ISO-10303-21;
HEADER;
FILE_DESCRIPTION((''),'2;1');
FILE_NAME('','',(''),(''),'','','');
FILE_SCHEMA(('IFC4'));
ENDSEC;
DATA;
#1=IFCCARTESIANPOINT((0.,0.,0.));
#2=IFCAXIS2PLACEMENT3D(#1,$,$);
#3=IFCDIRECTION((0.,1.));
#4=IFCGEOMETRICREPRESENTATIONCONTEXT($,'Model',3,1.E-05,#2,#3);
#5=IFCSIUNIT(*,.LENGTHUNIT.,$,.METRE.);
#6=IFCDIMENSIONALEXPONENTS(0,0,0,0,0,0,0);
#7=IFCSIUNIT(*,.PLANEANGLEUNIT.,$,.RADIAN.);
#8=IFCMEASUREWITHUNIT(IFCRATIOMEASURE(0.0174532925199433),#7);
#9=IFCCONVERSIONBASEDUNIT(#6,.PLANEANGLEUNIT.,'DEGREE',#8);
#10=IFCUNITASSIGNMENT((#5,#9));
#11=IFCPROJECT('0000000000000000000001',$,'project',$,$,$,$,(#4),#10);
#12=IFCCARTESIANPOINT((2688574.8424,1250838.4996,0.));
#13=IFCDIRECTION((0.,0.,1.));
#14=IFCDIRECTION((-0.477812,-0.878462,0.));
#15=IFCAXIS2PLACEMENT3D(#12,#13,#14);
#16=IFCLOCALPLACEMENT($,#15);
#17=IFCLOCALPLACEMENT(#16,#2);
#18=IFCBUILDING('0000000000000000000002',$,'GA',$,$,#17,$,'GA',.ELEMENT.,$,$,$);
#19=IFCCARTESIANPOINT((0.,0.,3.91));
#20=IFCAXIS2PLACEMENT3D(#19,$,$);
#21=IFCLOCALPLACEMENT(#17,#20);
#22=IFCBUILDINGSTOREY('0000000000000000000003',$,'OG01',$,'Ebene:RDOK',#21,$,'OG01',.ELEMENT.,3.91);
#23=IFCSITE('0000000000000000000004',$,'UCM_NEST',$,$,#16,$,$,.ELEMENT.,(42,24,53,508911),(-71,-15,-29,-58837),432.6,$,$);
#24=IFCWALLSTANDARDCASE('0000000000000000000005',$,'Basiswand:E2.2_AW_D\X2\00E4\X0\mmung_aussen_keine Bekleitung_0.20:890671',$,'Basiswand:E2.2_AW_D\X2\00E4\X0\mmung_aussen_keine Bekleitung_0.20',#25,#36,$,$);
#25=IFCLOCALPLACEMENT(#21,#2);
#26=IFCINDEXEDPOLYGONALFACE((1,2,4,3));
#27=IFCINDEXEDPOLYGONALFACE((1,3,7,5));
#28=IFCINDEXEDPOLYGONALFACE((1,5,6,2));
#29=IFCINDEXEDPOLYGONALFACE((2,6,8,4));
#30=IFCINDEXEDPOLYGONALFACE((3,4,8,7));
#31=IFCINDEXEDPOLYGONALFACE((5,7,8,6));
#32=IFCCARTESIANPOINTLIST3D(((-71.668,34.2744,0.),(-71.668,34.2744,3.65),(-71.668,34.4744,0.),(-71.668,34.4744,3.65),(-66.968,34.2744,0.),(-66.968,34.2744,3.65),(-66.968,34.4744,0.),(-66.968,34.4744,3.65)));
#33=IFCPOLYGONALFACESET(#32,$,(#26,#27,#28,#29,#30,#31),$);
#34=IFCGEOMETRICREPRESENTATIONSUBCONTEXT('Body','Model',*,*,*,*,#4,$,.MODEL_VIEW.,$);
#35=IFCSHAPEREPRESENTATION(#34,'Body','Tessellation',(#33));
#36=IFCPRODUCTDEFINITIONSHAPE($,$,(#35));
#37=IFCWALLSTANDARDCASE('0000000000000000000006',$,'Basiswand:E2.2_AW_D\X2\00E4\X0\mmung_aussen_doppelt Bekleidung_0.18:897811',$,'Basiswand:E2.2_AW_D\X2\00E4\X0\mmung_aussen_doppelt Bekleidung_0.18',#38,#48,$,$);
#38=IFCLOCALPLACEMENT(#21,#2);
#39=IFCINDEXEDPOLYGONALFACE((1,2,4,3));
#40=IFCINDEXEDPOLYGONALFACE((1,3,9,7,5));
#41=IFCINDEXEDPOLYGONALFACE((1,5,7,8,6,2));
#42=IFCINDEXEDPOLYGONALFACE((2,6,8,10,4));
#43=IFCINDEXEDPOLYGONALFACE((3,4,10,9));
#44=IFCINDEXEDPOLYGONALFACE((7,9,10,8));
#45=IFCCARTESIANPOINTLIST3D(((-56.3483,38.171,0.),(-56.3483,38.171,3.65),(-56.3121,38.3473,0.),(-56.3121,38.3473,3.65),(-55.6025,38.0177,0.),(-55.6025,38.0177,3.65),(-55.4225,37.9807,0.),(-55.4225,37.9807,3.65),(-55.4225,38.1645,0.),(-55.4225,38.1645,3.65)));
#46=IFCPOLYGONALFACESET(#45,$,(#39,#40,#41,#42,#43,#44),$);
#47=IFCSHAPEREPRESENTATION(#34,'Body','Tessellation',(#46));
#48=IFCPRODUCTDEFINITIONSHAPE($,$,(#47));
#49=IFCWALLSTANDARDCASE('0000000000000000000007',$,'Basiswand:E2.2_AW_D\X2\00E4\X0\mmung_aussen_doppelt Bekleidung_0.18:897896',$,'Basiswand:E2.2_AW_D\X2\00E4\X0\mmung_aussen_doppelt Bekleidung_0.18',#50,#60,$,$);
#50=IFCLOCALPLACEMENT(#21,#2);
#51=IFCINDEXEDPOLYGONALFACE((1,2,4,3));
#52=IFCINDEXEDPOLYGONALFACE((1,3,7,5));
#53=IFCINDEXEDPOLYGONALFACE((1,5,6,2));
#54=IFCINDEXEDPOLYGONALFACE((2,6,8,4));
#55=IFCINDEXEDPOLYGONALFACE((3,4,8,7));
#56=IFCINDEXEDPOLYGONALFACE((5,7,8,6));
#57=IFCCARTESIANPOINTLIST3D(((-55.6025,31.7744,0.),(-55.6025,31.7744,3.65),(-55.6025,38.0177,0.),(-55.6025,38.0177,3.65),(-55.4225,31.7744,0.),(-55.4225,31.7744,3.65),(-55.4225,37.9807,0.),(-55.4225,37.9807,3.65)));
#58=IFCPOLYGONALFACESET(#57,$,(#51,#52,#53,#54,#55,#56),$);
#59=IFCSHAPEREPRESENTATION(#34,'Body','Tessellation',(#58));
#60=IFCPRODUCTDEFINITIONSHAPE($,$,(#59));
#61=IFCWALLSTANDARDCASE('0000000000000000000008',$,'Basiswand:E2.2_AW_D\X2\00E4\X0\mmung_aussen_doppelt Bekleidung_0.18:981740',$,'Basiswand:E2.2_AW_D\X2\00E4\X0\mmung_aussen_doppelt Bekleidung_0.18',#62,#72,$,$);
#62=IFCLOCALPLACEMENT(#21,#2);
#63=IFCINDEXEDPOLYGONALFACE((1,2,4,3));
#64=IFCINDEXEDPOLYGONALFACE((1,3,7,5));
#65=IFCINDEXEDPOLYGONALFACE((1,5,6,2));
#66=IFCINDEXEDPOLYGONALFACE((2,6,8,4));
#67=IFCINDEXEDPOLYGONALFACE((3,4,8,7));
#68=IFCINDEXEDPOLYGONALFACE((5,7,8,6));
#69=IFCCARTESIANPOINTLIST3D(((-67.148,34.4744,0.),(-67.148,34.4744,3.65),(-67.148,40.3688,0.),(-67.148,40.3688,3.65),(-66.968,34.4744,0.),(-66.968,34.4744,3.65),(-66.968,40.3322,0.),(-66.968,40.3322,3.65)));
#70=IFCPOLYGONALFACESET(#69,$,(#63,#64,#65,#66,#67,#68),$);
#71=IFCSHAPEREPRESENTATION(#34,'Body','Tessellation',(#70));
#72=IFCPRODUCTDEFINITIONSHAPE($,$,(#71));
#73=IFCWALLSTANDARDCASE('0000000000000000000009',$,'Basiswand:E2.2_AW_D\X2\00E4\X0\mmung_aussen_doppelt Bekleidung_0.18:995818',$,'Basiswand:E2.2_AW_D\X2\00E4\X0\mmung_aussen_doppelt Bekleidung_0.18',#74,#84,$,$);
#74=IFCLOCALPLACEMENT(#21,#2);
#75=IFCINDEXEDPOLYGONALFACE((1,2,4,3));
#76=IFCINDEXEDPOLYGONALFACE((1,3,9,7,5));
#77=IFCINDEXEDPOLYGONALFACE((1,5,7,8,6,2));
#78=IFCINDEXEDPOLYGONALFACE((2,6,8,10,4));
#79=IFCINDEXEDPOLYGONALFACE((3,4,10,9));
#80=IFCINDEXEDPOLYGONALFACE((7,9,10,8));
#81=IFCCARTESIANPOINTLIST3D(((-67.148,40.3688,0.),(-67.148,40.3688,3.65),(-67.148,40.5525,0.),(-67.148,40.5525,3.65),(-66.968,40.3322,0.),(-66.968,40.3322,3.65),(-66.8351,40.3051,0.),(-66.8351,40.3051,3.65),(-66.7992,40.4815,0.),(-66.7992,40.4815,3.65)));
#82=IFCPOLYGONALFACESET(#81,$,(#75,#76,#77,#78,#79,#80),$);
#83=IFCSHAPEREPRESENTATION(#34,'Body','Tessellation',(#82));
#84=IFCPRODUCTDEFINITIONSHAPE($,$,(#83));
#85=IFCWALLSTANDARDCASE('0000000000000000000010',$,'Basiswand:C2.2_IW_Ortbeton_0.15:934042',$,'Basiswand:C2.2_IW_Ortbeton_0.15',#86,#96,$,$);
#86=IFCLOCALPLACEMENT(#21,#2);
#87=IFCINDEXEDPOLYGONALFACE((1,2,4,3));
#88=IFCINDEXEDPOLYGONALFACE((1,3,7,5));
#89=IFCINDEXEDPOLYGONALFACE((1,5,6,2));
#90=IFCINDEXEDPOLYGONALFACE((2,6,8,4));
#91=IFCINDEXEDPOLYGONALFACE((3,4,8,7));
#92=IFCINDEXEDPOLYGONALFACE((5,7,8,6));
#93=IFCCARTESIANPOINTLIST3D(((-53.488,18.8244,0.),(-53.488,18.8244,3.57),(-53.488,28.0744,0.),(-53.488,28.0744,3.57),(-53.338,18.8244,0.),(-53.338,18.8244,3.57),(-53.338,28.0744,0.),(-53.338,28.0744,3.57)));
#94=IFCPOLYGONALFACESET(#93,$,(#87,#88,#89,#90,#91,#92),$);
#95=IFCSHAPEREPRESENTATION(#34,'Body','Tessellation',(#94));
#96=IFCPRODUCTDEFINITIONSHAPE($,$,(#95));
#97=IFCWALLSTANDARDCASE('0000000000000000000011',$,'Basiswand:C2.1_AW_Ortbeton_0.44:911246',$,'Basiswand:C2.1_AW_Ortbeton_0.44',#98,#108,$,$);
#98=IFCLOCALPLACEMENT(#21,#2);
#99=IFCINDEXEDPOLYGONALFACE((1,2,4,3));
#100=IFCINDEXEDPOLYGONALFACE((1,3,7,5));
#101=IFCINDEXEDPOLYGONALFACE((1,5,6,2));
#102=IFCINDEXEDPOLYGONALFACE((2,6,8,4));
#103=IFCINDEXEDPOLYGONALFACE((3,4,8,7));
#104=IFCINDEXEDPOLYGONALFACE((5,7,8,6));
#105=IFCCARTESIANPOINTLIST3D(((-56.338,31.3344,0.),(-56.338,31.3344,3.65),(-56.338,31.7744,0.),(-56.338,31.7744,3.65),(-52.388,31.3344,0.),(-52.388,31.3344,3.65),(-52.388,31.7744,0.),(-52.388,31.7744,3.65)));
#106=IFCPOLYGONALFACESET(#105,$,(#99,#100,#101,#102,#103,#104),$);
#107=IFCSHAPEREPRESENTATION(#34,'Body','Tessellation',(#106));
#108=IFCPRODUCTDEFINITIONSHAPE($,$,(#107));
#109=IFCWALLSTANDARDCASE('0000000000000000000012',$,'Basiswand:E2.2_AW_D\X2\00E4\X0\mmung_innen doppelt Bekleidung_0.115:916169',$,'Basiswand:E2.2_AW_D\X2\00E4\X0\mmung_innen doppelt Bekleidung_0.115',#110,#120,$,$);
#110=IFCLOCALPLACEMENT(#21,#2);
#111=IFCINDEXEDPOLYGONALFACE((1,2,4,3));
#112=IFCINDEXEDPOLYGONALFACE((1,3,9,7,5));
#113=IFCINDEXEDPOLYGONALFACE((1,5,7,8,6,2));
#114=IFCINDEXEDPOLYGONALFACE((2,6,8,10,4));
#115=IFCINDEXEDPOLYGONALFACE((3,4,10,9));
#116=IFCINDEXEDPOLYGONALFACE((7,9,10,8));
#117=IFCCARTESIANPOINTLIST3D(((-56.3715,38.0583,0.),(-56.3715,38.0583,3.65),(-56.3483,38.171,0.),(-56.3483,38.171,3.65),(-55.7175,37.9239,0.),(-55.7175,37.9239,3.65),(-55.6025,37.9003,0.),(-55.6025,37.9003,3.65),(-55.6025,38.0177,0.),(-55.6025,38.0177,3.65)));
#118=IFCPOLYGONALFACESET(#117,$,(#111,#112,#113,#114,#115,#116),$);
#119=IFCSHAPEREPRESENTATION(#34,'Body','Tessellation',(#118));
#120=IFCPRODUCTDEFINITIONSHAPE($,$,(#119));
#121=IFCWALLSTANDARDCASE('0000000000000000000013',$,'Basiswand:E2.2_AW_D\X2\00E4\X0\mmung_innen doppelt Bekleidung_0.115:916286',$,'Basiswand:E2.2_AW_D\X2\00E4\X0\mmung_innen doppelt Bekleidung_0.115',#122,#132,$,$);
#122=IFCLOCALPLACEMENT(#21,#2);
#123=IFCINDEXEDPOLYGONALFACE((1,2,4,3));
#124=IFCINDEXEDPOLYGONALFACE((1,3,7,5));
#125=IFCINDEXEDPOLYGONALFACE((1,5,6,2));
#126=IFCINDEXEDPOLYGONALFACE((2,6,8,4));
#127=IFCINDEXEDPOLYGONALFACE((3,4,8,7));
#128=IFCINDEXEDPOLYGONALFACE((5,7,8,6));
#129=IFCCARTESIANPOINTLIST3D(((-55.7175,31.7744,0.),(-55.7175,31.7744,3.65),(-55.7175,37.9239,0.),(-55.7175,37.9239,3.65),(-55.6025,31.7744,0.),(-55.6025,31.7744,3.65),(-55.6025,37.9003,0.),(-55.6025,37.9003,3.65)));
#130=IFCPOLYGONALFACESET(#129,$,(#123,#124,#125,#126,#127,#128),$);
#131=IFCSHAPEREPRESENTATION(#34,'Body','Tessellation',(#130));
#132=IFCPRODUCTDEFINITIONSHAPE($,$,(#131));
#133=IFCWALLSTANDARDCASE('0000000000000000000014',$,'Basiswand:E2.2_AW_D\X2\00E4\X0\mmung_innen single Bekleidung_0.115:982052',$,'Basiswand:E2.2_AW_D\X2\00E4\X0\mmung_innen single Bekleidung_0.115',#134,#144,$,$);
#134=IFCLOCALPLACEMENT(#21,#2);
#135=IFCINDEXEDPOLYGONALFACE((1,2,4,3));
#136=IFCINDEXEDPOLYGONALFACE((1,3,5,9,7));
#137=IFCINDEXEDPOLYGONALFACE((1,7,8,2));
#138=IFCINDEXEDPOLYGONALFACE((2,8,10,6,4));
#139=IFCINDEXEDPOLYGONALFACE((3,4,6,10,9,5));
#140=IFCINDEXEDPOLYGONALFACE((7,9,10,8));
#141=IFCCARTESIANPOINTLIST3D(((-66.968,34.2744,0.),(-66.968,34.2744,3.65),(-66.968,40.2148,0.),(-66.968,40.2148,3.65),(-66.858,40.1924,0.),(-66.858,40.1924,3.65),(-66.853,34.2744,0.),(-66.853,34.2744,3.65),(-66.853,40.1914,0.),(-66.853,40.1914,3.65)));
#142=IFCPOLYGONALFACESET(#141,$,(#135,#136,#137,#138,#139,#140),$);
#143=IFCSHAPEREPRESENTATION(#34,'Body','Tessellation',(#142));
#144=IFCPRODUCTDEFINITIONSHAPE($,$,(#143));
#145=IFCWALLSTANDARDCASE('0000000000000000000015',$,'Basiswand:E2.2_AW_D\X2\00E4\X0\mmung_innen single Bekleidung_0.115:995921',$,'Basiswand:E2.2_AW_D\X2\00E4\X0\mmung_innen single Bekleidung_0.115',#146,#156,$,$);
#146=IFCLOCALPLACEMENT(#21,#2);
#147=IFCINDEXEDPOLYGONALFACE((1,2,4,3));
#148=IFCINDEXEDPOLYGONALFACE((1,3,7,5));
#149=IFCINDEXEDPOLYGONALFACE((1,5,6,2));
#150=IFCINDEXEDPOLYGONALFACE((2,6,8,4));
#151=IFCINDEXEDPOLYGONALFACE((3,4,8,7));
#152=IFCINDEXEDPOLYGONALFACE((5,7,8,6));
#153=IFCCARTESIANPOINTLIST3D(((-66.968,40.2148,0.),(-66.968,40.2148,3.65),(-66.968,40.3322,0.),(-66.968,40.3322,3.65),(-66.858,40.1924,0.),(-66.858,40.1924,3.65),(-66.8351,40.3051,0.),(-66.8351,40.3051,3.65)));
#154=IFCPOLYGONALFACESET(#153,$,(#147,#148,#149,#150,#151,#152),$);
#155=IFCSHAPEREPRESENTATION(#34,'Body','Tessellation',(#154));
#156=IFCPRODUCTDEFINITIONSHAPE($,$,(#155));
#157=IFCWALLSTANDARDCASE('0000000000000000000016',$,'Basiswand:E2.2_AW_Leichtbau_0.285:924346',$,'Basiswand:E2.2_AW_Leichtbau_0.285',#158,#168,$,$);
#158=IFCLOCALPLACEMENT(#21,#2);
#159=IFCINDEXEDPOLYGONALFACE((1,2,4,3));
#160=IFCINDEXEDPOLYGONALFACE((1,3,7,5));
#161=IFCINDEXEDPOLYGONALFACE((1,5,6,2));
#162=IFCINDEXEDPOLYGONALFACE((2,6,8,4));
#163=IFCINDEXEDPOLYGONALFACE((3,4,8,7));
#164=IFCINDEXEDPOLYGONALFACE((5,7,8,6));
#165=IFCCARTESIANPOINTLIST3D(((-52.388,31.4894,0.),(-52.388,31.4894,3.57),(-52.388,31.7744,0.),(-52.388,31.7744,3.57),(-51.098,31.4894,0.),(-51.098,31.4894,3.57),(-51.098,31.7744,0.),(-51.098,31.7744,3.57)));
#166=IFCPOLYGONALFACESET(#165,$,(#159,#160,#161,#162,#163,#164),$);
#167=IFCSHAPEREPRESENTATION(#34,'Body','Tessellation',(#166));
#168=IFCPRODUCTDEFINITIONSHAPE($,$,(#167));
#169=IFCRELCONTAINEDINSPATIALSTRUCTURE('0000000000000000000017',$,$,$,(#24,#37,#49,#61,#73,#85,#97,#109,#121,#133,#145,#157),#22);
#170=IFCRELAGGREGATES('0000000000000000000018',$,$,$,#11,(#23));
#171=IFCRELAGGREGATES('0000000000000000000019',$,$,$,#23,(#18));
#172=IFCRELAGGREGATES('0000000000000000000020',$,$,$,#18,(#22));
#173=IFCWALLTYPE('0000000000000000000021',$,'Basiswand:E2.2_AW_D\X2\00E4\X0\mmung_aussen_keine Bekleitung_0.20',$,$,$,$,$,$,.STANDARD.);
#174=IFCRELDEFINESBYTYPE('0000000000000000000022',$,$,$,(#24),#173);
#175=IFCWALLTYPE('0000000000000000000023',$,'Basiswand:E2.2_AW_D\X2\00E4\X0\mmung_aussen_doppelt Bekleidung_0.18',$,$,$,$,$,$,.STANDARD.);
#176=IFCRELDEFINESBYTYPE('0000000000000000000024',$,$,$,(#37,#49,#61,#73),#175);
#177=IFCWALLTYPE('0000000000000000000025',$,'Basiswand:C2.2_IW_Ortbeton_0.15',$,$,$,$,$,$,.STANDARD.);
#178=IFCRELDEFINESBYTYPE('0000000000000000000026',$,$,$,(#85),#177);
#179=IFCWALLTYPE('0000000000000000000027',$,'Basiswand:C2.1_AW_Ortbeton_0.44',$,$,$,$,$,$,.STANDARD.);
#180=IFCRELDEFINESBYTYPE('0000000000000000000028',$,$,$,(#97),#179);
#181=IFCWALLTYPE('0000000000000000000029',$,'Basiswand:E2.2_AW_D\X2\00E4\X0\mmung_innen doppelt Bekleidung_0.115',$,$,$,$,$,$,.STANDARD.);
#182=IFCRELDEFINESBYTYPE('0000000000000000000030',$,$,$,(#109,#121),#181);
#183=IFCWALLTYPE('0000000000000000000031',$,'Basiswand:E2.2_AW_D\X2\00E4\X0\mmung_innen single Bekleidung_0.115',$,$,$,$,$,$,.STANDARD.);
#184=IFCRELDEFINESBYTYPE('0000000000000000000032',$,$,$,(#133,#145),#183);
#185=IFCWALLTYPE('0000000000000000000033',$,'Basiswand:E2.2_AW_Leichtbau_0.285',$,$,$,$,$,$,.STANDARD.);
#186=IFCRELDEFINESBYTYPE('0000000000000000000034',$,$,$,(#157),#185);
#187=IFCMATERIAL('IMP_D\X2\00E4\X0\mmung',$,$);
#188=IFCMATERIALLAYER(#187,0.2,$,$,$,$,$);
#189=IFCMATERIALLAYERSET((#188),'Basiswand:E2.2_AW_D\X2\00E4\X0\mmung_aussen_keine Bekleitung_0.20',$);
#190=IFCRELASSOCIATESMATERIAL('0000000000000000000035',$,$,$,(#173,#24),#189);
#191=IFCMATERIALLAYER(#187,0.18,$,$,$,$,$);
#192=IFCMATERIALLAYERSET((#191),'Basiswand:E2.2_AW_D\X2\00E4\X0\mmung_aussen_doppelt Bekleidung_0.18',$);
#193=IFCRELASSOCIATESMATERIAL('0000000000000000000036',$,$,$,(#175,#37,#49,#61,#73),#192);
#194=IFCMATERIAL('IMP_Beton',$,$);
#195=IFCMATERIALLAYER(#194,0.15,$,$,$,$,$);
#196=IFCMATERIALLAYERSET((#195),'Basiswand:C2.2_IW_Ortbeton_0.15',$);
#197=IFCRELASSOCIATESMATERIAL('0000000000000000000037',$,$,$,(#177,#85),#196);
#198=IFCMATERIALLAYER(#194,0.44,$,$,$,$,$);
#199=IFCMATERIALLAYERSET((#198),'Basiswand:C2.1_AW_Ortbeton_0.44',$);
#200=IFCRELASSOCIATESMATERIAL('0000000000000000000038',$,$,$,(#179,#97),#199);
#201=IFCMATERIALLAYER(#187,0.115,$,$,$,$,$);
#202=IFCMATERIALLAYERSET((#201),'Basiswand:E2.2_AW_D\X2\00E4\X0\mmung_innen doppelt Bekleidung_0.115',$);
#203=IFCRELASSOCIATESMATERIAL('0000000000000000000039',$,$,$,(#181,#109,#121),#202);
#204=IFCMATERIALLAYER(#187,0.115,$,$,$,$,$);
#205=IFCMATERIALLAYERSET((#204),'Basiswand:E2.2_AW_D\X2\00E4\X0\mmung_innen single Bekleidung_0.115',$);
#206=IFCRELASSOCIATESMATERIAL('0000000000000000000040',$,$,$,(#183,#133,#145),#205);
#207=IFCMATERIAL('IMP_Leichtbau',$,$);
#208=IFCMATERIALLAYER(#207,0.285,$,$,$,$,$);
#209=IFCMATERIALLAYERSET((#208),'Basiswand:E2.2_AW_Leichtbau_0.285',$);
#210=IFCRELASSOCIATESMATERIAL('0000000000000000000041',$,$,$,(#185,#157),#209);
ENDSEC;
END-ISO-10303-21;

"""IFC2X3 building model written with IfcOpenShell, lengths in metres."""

from ifc_helpers import new_model, entity, si_unit, converted_unit, direction, frame, frame_2d, origin, place, context, subcontext, project, spatial, polyline, rectangle, outline, extrude, clip, bounded_halfspace, material, layer, layer_set, layer_usage, type_object, element, save


model = new_model("IFC2X3")

# Units and contexts
model_context = context("Model", 3, precision=1e-05, world=origin(), true_north=direction((0.0, 1.0)))
body_context = subcontext(model_context, "Body", "Model", "MODEL_VIEW")
ifc_project = project(units=[si_unit("LENGTHUNIT", "METRE"), converted_unit("PLANEANGLEUNIT", "DEGREE", entity("IfcRatioMeasure", 0.0174532925199433), si_unit("PLANEANGLEUNIT", "RADIAN"), dimensions=[0, 0, 0, 0, 0, 0, 0])], contexts=[model_context])

# Site, building, storey
site_placement = place(None, frame((2688574.8424, 1250838.4996, 0.0), z_axis=(0.0, 0.0, 1.0), x_axis=(-0.477812, -0.878462, 0.0)))
site = spatial("IfcSite", under=ifc_project, at=site_placement, Name="UCM_NEST", CompositionType="ELEMENT", RefLatitude=(42, 24, 53, 508911), RefLongitude=(-71, -15, -29, -58837), RefElevation=432.6)
building_placement = place(site_placement, origin())
building = spatial("IfcBuilding", under=site, at=building_placement, Name="GA", LongName="GA", CompositionType="ELEMENT")
storey_placement = place(building_placement, frame((0.0, 0.0, 3.91)))
storey = spatial("IfcBuildingStorey", under=building, at=storey_placement, Name="OG01", ObjectType="Ebene:RDOK", LongName="OG01", CompositionType="ELEMENT", Elevation=3.91)

# Walls
ifc_material_1 = material(Name="IMP_Dämmung")
ifc_layer_1 = layer(ifc_material_1, 0.2)
ifc_layer_set_1 = layer_set([ifc_layer_1], Name="Basiswand:E2.2_AW_Dämmung_aussen_keine Bekleitung_0.20")
ifc_layer_usage_1 = layer_usage(ifc_layer_set_1, "AXIS2", "NEGATIVE", 0.1)
wall_type_1 = type_object("IfcWallType", Name="Basiswand:E2.2_AW_Dämmung_aussen_keine Bekleitung_0.20", PredefinedType="STANDARD", material=ifc_layer_set_1)
wall_1_placement = place(storey_placement, frame((-66.968, 34.3744, 0.0), z_axis=(0.0, 0.0, 1.0), x_axis=(-1.0, 0.0, 0.0)))
element("IfcWallStandardCase", 1, at=wall_1_placement, inside=storey, type_object=wall_type_1, material=ifc_layer_usage_1, Name="Basiswand:E2.2_AW_Dämmung_aussen_keine Bekleitung_0.20:890671", ObjectType="Basiswand:E2.2_AW_Dämmung_aussen_keine Bekleitung_0.20", context=body_context, shape_type="SweptSolid", body=[
    extrude(rectangle(XDim=4.7, YDim=0.2, at=frame_2d((2.35, 0.0), x_axis=(-1.0, 0.0))), origin(), (0.0, 0.0, 1.0), 3.65),
])
ifc_layer_2 = layer(ifc_material_1, 0.18)
ifc_layer_set_2 = layer_set([ifc_layer_2], Name="Basiswand:E2.2_AW_Dämmung_aussen_doppelt Bekleidung_0.18")
ifc_layer_usage_2 = layer_usage(ifc_layer_set_2, "AXIS2", "NEGATIVE", 0.09)
wall_type_2 = type_object("IfcWallType", Name="Basiswand:E2.2_AW_Dämmung_aussen_doppelt Bekleidung_0.18", PredefinedType="STANDARD", material=ifc_layer_set_2)
wall_2_placement = place(storey_placement, frame((-56.3302, 38.2591, 0.0), z_axis=(0.0, 0.0, 1.0), x_axis=(0.979529, -0.201305, 0.0)))
element("IfcWallStandardCase", 2, at=wall_2_placement, inside=storey, type_object=wall_type_2, material=ifc_layer_usage_2, Name="Basiswand:E2.2_AW_Dämmung_aussen_doppelt Bekleidung_0.18:897811", ObjectType="Basiswand:E2.2_AW_Dämmung_aussen_doppelt Bekleidung_0.18", context=body_context, shape_type="SweptSolid", body=[
    extrude(outline(polyline([(0.9451, -0.09), (0.9081, 0.09), (0.0, 0.09), (0.0, -0.09), (0.7614, -0.09), (0.9451, -0.09)])), origin(), (0.0, 0.0, 1.0), 3.65),
])
ifc_layer_usage_3 = layer_usage(ifc_layer_set_2, "AXIS2", "NEGATIVE", 0.09)
wall_3_placement = place(storey_placement, frame((-55.5125, 38.0177, 0.0), z_axis=(0.0, 0.0, 1.0), x_axis=(0.0, -1.0, 0.0)))
element("IfcWallStandardCase", 3, at=wall_3_placement, inside=storey, type_object=wall_type_2, material=ifc_layer_usage_3, Name="Basiswand:E2.2_AW_Dämmung_aussen_doppelt Bekleidung_0.18:897896", ObjectType="Basiswand:E2.2_AW_Dämmung_aussen_doppelt Bekleidung_0.18", context=body_context, shape_type="SweptSolid", body=[
    extrude(outline(polyline([(6.2433, -0.09), (6.2433, 0.09), (0.037, 0.09), (0.0, -0.09), (6.2433, -0.09)])), origin(), (0.0, 0.0, 1.0), 3.65),
])
ifc_layer_usage_4 = layer_usage(ifc_layer_set_2, "AXIS2", "NEGATIVE", 0.09)
wall_4_placement = place(storey_placement, frame((-67.058, 34.4744, 0.0), z_axis=(0.0, 0.0, 1.0), x_axis=(0.0, 1.0, 0.0)))
element("IfcWallStandardCase", 4, at=wall_4_placement, inside=storey, type_object=wall_type_2, material=ifc_layer_usage_4, Name="Basiswand:E2.2_AW_Dämmung_aussen_doppelt Bekleidung_0.18:981740", ObjectType="Basiswand:E2.2_AW_Dämmung_aussen_doppelt Bekleidung_0.18", context=body_context, shape_type="SweptSolid", body=[
    extrude(outline(polyline([(5.8577, -0.09), (5.8943, 0.09), (0.0, 0.09), (0.0, -0.09), (5.8577, -0.09)])), origin(), (0.0, 0.0, 1.0), 3.65),
])
ifc_layer_usage_5 = layer_usage(ifc_layer_set_2, "AXIS2", "NEGATIVE", 0.09)
wall_5_placement = place(storey_placement, frame((-67.1659, 40.4643, 0.0), z_axis=(0.0, 0.0, 1.0), x_axis=(0.979914, -0.199421, 0.0)))
element("IfcWallStandardCase", 5, at=wall_5_placement, inside=storey, type_object=wall_type_2, material=ifc_layer_usage_5, Name="Basiswand:E2.2_AW_Dämmung_aussen_doppelt Bekleidung_0.18:995818", ObjectType="Basiswand:E2.2_AW_Dämmung_aussen_doppelt Bekleidung_0.18", context=body_context, shape_type="SweptSolid", body=[
    extrude(outline(polyline([(0.356, -0.09), (0.356, 0.09), (0.0, 0.09), (0.0366, -0.09), (0.2203, -0.09), (0.356, -0.09)])), origin(), (0.0, 0.0, 1.0), 3.65),
])
ifc_material_2 = material(Name="IMP_Beton")
ifc_layer_3 = layer(ifc_material_2, 0.15)
ifc_layer_set_3 = layer_set([ifc_layer_3], Name="Basiswand:C2.2_IW_Ortbeton_0.15")
ifc_layer_usage_6 = layer_usage(ifc_layer_set_3, "AXIS2", "NEGATIVE", 0.075)
wall_type_3 = type_object("IfcWallType", Name="Basiswand:C2.2_IW_Ortbeton_0.15", PredefinedType="STANDARD", material=ifc_layer_set_3)
wall_6_placement = place(storey_placement, frame((-53.413, 28.0744, 0.0), z_axis=(0.0, 0.0, 1.0), x_axis=(0.0, -1.0, 0.0)))
element("IfcWallStandardCase", 6, at=wall_6_placement, inside=storey, type_object=wall_type_3, material=ifc_layer_usage_6, Name="Basiswand:C2.2_IW_Ortbeton_0.15:934042", ObjectType="Basiswand:C2.2_IW_Ortbeton_0.15", context=body_context, shape_type="Clipping", body=[
    clip(extrude(rectangle(XDim=9.25, YDim=0.15, at=frame_2d((4.625, 0.0), x_axis=(-1.0, 0.0))), origin(), (0.0, 0.0, 1.0), 3.57), bounded_halfspace(frame((0.0, -0.075, 3.57), z_axis=(0.0, 0.0, -1.0), x_axis=(1.0, 0.0, 0.0)), True, frame((0.0, -0.075, 3.57), z_axis=(0.0, 0.0, -1.0), x_axis=(1.0, 0.0, 0.0)), polyline([(0.0, 0.0), (0.0, -0.15), (9.1, -0.15), (9.25, -0.15), (9.25, 0.0), (0.0, 0.0)]))),
])
ifc_layer_4 = layer(ifc_material_2, 0.44)
ifc_layer_set_4 = layer_set([ifc_layer_4], Name="Basiswand:C2.1_AW_Ortbeton_0.44")
ifc_layer_usage_7 = layer_usage(ifc_layer_set_4, "AXIS2", "NEGATIVE", 0.22)
wall_type_4 = type_object("IfcWallType", Name="Basiswand:C2.1_AW_Ortbeton_0.44", PredefinedType="STANDARD", material=ifc_layer_set_4)
wall_7_placement = place(storey_placement, frame((-56.338, 31.5544, 0.0)))
element("IfcWallStandardCase", 7, at=wall_7_placement, inside=storey, type_object=wall_type_4, material=ifc_layer_usage_7, Name="Basiswand:C2.1_AW_Ortbeton_0.44:911246", ObjectType="Basiswand:C2.1_AW_Ortbeton_0.44", context=body_context, shape_type="SweptSolid", body=[
    extrude(rectangle(XDim=3.95, YDim=0.44, at=frame_2d((1.975, 0.0), x_axis=(-1.0, 0.0))), origin(), (0.0, 0.0, 1.0), 3.65),
])

# Walls
ifc_layer_5 = layer(ifc_material_1, 0.115)
ifc_layer_set_5 = layer_set([ifc_layer_5], Name="Basiswand:E2.2_AW_Dämmung_innen doppelt Bekleidung_0.115")
ifc_layer_usage_8 = layer_usage(ifc_layer_set_5, "AXIS2", "NEGATIVE", 0.0575)
wall_type_5 = type_object("IfcWallType", Name="Basiswand:E2.2_AW_Dämmung_innen doppelt Bekleidung_0.115", PredefinedType="STANDARD", material=ifc_layer_set_5)
wall_8_placement = place(storey_placement, frame((-56.3599, 38.1146, 0.0), z_axis=(0.0, 0.0, 1.0), x_axis=(0.979529, -0.201305, 0.0)))
element("IfcWallStandardCase", 8, at=wall_8_placement, inside=storey, type_object=wall_type_5, material=ifc_layer_usage_8, Name="Basiswand:E2.2_AW_Dämmung_innen doppelt Bekleidung_0.115:916169", ObjectType="Basiswand:E2.2_AW_Dämmung_innen doppelt Bekleidung_0.115", context=body_context, shape_type="SweptSolid", body=[
    extrude(outline(polyline([(0.785, -0.0575), (0.7614, 0.0575), (0.0, 0.0575), (0.0, -0.0575), (0.6676, -0.0575), (0.785, -0.0575)])), origin(), (0.0, 0.0, 1.0), 3.65),
])
ifc_layer_usage_9 = layer_usage(ifc_layer_set_5, "AXIS2", "NEGATIVE", 0.0575)
wall_9_placement = place(storey_placement, frame((-55.66, 37.9239, 0.0), z_axis=(0.0, 0.0, 1.0), x_axis=(0.0, -1.0, 0.0)))
element("IfcWallStandardCase", 9, at=wall_9_placement, inside=storey, type_object=wall_type_5, material=ifc_layer_usage_9, Name="Basiswand:E2.2_AW_Dämmung_innen doppelt Bekleidung_0.115:916286", ObjectType="Basiswand:E2.2_AW_Dämmung_innen doppelt Bekleidung_0.115", context=body_context, shape_type="SweptSolid", body=[
    extrude(outline(polyline([(6.1495, -0.0575), (6.1495, 0.0575), (0.0236, 0.0575), (0.0, -0.0575), (6.1495, -0.0575)])), origin(), (0.0, 0.0, 1.0), 3.65),
])
ifc_layer_6 = layer(ifc_material_1, 0.115)
ifc_layer_set_6 = layer_set([ifc_layer_6], Name="Basiswand:E2.2_AW_Dämmung_innen single Bekleidung_0.115")
ifc_layer_usage_10 = layer_usage(ifc_layer_set_6, "AXIS2", "NEGATIVE", 0.0575)
wall_type_6 = type_object("IfcWallType", Name="Basiswand:E2.2_AW_Dämmung_innen single Bekleidung_0.115", PredefinedType="STANDARD", material=ifc_layer_set_6)
wall_10_placement = place(storey_placement, frame((-66.9105, 34.2744, 0.0), z_axis=(0.0, 0.0, 1.0), x_axis=(0.0, 1.0, 0.0)))
element("IfcWallStandardCase", 10, at=wall_10_placement, inside=storey, type_object=wall_type_6, material=ifc_layer_usage_10, Name="Basiswand:E2.2_AW_Dämmung_innen single Bekleidung_0.115:982052", ObjectType="Basiswand:E2.2_AW_Dämmung_innen single Bekleidung_0.115", context=body_context, shape_type="SweptSolid", body=[
    extrude(outline(polyline([(5.917, -0.0575), (5.918, -0.0525), (5.9404, 0.0575), (0.0, 0.0575), (0.0, -0.0575), (5.917, -0.0575)])), origin(), (0.0, 0.0, 1.0), 3.65),
])
ifc_layer_usage_11 = layer_usage(ifc_layer_set_6, "AXIS2", "NEGATIVE", 0.0575)
wall_11_placement = place(storey_placement, frame((-66.9795, 40.2758, 0.0), z_axis=(0.0, 0.0, 1.0), x_axis=(0.979914, -0.199421, 0.0)))
element("IfcWallStandardCase", 11, at=wall_11_placement, inside=storey, type_object=wall_type_6, material=ifc_layer_usage_11, Name="Basiswand:E2.2_AW_Dämmung_innen single Bekleidung_0.115:995921", ObjectType="Basiswand:E2.2_AW_Dämmung_innen single Bekleidung_0.115", context=body_context, shape_type="SweptSolid", body=[
    extrude(outline(polyline([(0.1357, -0.0575), (0.1357, 0.0575), (0.0, 0.0575), (0.0234, -0.0575), (0.1357, -0.0575)])), origin(), (0.0, 0.0, 1.0), 3.65),
])
ifc_material_3 = material(Name="IMP_Leichtbau")
ifc_layer_7 = layer(ifc_material_3, 0.285)
ifc_layer_set_7 = layer_set([ifc_layer_7], Name="Basiswand:E2.2_AW_Leichtbau_0.285")
ifc_layer_usage_12 = layer_usage(ifc_layer_set_7, "AXIS2", "NEGATIVE", 0.1425)
wall_type_7 = type_object("IfcWallType", Name="Basiswand:E2.2_AW_Leichtbau_0.285", PredefinedType="STANDARD", material=ifc_layer_set_7)
wall_12_placement = place(storey_placement, frame((-52.388, 31.6319, 0.0)))
element("IfcWallStandardCase", 12, at=wall_12_placement, inside=storey, type_object=wall_type_7, material=ifc_layer_usage_12, Name="Basiswand:E2.2_AW_Leichtbau_0.285:924346", ObjectType="Basiswand:E2.2_AW_Leichtbau_0.285", context=body_context, shape_type="Clipping", body=[
    clip(extrude(rectangle(XDim=1.29, YDim=0.285, at=frame_2d((0.645, 0.0), x_axis=(-1.0, 0.0))), origin(), (0.0, 0.0, 1.0), 3.57), bounded_halfspace(frame((0.0, -0.1425, 3.57), z_axis=(0.0, 0.0, -1.0), x_axis=(0.0, -1.0, 0.0)), True, frame((0.0, -0.1425, 3.57), z_axis=(0.0, 0.0, -1.0), x_axis=(0.0, -1.0, 0.0)), polyline([(0.0, 0.0), (-0.285, 0.0), (-0.285, -1.29), (0.0, -1.29), (0.0, -1.11), (0.0, 0.0)]))),
])

save(model, "model.ifc")
